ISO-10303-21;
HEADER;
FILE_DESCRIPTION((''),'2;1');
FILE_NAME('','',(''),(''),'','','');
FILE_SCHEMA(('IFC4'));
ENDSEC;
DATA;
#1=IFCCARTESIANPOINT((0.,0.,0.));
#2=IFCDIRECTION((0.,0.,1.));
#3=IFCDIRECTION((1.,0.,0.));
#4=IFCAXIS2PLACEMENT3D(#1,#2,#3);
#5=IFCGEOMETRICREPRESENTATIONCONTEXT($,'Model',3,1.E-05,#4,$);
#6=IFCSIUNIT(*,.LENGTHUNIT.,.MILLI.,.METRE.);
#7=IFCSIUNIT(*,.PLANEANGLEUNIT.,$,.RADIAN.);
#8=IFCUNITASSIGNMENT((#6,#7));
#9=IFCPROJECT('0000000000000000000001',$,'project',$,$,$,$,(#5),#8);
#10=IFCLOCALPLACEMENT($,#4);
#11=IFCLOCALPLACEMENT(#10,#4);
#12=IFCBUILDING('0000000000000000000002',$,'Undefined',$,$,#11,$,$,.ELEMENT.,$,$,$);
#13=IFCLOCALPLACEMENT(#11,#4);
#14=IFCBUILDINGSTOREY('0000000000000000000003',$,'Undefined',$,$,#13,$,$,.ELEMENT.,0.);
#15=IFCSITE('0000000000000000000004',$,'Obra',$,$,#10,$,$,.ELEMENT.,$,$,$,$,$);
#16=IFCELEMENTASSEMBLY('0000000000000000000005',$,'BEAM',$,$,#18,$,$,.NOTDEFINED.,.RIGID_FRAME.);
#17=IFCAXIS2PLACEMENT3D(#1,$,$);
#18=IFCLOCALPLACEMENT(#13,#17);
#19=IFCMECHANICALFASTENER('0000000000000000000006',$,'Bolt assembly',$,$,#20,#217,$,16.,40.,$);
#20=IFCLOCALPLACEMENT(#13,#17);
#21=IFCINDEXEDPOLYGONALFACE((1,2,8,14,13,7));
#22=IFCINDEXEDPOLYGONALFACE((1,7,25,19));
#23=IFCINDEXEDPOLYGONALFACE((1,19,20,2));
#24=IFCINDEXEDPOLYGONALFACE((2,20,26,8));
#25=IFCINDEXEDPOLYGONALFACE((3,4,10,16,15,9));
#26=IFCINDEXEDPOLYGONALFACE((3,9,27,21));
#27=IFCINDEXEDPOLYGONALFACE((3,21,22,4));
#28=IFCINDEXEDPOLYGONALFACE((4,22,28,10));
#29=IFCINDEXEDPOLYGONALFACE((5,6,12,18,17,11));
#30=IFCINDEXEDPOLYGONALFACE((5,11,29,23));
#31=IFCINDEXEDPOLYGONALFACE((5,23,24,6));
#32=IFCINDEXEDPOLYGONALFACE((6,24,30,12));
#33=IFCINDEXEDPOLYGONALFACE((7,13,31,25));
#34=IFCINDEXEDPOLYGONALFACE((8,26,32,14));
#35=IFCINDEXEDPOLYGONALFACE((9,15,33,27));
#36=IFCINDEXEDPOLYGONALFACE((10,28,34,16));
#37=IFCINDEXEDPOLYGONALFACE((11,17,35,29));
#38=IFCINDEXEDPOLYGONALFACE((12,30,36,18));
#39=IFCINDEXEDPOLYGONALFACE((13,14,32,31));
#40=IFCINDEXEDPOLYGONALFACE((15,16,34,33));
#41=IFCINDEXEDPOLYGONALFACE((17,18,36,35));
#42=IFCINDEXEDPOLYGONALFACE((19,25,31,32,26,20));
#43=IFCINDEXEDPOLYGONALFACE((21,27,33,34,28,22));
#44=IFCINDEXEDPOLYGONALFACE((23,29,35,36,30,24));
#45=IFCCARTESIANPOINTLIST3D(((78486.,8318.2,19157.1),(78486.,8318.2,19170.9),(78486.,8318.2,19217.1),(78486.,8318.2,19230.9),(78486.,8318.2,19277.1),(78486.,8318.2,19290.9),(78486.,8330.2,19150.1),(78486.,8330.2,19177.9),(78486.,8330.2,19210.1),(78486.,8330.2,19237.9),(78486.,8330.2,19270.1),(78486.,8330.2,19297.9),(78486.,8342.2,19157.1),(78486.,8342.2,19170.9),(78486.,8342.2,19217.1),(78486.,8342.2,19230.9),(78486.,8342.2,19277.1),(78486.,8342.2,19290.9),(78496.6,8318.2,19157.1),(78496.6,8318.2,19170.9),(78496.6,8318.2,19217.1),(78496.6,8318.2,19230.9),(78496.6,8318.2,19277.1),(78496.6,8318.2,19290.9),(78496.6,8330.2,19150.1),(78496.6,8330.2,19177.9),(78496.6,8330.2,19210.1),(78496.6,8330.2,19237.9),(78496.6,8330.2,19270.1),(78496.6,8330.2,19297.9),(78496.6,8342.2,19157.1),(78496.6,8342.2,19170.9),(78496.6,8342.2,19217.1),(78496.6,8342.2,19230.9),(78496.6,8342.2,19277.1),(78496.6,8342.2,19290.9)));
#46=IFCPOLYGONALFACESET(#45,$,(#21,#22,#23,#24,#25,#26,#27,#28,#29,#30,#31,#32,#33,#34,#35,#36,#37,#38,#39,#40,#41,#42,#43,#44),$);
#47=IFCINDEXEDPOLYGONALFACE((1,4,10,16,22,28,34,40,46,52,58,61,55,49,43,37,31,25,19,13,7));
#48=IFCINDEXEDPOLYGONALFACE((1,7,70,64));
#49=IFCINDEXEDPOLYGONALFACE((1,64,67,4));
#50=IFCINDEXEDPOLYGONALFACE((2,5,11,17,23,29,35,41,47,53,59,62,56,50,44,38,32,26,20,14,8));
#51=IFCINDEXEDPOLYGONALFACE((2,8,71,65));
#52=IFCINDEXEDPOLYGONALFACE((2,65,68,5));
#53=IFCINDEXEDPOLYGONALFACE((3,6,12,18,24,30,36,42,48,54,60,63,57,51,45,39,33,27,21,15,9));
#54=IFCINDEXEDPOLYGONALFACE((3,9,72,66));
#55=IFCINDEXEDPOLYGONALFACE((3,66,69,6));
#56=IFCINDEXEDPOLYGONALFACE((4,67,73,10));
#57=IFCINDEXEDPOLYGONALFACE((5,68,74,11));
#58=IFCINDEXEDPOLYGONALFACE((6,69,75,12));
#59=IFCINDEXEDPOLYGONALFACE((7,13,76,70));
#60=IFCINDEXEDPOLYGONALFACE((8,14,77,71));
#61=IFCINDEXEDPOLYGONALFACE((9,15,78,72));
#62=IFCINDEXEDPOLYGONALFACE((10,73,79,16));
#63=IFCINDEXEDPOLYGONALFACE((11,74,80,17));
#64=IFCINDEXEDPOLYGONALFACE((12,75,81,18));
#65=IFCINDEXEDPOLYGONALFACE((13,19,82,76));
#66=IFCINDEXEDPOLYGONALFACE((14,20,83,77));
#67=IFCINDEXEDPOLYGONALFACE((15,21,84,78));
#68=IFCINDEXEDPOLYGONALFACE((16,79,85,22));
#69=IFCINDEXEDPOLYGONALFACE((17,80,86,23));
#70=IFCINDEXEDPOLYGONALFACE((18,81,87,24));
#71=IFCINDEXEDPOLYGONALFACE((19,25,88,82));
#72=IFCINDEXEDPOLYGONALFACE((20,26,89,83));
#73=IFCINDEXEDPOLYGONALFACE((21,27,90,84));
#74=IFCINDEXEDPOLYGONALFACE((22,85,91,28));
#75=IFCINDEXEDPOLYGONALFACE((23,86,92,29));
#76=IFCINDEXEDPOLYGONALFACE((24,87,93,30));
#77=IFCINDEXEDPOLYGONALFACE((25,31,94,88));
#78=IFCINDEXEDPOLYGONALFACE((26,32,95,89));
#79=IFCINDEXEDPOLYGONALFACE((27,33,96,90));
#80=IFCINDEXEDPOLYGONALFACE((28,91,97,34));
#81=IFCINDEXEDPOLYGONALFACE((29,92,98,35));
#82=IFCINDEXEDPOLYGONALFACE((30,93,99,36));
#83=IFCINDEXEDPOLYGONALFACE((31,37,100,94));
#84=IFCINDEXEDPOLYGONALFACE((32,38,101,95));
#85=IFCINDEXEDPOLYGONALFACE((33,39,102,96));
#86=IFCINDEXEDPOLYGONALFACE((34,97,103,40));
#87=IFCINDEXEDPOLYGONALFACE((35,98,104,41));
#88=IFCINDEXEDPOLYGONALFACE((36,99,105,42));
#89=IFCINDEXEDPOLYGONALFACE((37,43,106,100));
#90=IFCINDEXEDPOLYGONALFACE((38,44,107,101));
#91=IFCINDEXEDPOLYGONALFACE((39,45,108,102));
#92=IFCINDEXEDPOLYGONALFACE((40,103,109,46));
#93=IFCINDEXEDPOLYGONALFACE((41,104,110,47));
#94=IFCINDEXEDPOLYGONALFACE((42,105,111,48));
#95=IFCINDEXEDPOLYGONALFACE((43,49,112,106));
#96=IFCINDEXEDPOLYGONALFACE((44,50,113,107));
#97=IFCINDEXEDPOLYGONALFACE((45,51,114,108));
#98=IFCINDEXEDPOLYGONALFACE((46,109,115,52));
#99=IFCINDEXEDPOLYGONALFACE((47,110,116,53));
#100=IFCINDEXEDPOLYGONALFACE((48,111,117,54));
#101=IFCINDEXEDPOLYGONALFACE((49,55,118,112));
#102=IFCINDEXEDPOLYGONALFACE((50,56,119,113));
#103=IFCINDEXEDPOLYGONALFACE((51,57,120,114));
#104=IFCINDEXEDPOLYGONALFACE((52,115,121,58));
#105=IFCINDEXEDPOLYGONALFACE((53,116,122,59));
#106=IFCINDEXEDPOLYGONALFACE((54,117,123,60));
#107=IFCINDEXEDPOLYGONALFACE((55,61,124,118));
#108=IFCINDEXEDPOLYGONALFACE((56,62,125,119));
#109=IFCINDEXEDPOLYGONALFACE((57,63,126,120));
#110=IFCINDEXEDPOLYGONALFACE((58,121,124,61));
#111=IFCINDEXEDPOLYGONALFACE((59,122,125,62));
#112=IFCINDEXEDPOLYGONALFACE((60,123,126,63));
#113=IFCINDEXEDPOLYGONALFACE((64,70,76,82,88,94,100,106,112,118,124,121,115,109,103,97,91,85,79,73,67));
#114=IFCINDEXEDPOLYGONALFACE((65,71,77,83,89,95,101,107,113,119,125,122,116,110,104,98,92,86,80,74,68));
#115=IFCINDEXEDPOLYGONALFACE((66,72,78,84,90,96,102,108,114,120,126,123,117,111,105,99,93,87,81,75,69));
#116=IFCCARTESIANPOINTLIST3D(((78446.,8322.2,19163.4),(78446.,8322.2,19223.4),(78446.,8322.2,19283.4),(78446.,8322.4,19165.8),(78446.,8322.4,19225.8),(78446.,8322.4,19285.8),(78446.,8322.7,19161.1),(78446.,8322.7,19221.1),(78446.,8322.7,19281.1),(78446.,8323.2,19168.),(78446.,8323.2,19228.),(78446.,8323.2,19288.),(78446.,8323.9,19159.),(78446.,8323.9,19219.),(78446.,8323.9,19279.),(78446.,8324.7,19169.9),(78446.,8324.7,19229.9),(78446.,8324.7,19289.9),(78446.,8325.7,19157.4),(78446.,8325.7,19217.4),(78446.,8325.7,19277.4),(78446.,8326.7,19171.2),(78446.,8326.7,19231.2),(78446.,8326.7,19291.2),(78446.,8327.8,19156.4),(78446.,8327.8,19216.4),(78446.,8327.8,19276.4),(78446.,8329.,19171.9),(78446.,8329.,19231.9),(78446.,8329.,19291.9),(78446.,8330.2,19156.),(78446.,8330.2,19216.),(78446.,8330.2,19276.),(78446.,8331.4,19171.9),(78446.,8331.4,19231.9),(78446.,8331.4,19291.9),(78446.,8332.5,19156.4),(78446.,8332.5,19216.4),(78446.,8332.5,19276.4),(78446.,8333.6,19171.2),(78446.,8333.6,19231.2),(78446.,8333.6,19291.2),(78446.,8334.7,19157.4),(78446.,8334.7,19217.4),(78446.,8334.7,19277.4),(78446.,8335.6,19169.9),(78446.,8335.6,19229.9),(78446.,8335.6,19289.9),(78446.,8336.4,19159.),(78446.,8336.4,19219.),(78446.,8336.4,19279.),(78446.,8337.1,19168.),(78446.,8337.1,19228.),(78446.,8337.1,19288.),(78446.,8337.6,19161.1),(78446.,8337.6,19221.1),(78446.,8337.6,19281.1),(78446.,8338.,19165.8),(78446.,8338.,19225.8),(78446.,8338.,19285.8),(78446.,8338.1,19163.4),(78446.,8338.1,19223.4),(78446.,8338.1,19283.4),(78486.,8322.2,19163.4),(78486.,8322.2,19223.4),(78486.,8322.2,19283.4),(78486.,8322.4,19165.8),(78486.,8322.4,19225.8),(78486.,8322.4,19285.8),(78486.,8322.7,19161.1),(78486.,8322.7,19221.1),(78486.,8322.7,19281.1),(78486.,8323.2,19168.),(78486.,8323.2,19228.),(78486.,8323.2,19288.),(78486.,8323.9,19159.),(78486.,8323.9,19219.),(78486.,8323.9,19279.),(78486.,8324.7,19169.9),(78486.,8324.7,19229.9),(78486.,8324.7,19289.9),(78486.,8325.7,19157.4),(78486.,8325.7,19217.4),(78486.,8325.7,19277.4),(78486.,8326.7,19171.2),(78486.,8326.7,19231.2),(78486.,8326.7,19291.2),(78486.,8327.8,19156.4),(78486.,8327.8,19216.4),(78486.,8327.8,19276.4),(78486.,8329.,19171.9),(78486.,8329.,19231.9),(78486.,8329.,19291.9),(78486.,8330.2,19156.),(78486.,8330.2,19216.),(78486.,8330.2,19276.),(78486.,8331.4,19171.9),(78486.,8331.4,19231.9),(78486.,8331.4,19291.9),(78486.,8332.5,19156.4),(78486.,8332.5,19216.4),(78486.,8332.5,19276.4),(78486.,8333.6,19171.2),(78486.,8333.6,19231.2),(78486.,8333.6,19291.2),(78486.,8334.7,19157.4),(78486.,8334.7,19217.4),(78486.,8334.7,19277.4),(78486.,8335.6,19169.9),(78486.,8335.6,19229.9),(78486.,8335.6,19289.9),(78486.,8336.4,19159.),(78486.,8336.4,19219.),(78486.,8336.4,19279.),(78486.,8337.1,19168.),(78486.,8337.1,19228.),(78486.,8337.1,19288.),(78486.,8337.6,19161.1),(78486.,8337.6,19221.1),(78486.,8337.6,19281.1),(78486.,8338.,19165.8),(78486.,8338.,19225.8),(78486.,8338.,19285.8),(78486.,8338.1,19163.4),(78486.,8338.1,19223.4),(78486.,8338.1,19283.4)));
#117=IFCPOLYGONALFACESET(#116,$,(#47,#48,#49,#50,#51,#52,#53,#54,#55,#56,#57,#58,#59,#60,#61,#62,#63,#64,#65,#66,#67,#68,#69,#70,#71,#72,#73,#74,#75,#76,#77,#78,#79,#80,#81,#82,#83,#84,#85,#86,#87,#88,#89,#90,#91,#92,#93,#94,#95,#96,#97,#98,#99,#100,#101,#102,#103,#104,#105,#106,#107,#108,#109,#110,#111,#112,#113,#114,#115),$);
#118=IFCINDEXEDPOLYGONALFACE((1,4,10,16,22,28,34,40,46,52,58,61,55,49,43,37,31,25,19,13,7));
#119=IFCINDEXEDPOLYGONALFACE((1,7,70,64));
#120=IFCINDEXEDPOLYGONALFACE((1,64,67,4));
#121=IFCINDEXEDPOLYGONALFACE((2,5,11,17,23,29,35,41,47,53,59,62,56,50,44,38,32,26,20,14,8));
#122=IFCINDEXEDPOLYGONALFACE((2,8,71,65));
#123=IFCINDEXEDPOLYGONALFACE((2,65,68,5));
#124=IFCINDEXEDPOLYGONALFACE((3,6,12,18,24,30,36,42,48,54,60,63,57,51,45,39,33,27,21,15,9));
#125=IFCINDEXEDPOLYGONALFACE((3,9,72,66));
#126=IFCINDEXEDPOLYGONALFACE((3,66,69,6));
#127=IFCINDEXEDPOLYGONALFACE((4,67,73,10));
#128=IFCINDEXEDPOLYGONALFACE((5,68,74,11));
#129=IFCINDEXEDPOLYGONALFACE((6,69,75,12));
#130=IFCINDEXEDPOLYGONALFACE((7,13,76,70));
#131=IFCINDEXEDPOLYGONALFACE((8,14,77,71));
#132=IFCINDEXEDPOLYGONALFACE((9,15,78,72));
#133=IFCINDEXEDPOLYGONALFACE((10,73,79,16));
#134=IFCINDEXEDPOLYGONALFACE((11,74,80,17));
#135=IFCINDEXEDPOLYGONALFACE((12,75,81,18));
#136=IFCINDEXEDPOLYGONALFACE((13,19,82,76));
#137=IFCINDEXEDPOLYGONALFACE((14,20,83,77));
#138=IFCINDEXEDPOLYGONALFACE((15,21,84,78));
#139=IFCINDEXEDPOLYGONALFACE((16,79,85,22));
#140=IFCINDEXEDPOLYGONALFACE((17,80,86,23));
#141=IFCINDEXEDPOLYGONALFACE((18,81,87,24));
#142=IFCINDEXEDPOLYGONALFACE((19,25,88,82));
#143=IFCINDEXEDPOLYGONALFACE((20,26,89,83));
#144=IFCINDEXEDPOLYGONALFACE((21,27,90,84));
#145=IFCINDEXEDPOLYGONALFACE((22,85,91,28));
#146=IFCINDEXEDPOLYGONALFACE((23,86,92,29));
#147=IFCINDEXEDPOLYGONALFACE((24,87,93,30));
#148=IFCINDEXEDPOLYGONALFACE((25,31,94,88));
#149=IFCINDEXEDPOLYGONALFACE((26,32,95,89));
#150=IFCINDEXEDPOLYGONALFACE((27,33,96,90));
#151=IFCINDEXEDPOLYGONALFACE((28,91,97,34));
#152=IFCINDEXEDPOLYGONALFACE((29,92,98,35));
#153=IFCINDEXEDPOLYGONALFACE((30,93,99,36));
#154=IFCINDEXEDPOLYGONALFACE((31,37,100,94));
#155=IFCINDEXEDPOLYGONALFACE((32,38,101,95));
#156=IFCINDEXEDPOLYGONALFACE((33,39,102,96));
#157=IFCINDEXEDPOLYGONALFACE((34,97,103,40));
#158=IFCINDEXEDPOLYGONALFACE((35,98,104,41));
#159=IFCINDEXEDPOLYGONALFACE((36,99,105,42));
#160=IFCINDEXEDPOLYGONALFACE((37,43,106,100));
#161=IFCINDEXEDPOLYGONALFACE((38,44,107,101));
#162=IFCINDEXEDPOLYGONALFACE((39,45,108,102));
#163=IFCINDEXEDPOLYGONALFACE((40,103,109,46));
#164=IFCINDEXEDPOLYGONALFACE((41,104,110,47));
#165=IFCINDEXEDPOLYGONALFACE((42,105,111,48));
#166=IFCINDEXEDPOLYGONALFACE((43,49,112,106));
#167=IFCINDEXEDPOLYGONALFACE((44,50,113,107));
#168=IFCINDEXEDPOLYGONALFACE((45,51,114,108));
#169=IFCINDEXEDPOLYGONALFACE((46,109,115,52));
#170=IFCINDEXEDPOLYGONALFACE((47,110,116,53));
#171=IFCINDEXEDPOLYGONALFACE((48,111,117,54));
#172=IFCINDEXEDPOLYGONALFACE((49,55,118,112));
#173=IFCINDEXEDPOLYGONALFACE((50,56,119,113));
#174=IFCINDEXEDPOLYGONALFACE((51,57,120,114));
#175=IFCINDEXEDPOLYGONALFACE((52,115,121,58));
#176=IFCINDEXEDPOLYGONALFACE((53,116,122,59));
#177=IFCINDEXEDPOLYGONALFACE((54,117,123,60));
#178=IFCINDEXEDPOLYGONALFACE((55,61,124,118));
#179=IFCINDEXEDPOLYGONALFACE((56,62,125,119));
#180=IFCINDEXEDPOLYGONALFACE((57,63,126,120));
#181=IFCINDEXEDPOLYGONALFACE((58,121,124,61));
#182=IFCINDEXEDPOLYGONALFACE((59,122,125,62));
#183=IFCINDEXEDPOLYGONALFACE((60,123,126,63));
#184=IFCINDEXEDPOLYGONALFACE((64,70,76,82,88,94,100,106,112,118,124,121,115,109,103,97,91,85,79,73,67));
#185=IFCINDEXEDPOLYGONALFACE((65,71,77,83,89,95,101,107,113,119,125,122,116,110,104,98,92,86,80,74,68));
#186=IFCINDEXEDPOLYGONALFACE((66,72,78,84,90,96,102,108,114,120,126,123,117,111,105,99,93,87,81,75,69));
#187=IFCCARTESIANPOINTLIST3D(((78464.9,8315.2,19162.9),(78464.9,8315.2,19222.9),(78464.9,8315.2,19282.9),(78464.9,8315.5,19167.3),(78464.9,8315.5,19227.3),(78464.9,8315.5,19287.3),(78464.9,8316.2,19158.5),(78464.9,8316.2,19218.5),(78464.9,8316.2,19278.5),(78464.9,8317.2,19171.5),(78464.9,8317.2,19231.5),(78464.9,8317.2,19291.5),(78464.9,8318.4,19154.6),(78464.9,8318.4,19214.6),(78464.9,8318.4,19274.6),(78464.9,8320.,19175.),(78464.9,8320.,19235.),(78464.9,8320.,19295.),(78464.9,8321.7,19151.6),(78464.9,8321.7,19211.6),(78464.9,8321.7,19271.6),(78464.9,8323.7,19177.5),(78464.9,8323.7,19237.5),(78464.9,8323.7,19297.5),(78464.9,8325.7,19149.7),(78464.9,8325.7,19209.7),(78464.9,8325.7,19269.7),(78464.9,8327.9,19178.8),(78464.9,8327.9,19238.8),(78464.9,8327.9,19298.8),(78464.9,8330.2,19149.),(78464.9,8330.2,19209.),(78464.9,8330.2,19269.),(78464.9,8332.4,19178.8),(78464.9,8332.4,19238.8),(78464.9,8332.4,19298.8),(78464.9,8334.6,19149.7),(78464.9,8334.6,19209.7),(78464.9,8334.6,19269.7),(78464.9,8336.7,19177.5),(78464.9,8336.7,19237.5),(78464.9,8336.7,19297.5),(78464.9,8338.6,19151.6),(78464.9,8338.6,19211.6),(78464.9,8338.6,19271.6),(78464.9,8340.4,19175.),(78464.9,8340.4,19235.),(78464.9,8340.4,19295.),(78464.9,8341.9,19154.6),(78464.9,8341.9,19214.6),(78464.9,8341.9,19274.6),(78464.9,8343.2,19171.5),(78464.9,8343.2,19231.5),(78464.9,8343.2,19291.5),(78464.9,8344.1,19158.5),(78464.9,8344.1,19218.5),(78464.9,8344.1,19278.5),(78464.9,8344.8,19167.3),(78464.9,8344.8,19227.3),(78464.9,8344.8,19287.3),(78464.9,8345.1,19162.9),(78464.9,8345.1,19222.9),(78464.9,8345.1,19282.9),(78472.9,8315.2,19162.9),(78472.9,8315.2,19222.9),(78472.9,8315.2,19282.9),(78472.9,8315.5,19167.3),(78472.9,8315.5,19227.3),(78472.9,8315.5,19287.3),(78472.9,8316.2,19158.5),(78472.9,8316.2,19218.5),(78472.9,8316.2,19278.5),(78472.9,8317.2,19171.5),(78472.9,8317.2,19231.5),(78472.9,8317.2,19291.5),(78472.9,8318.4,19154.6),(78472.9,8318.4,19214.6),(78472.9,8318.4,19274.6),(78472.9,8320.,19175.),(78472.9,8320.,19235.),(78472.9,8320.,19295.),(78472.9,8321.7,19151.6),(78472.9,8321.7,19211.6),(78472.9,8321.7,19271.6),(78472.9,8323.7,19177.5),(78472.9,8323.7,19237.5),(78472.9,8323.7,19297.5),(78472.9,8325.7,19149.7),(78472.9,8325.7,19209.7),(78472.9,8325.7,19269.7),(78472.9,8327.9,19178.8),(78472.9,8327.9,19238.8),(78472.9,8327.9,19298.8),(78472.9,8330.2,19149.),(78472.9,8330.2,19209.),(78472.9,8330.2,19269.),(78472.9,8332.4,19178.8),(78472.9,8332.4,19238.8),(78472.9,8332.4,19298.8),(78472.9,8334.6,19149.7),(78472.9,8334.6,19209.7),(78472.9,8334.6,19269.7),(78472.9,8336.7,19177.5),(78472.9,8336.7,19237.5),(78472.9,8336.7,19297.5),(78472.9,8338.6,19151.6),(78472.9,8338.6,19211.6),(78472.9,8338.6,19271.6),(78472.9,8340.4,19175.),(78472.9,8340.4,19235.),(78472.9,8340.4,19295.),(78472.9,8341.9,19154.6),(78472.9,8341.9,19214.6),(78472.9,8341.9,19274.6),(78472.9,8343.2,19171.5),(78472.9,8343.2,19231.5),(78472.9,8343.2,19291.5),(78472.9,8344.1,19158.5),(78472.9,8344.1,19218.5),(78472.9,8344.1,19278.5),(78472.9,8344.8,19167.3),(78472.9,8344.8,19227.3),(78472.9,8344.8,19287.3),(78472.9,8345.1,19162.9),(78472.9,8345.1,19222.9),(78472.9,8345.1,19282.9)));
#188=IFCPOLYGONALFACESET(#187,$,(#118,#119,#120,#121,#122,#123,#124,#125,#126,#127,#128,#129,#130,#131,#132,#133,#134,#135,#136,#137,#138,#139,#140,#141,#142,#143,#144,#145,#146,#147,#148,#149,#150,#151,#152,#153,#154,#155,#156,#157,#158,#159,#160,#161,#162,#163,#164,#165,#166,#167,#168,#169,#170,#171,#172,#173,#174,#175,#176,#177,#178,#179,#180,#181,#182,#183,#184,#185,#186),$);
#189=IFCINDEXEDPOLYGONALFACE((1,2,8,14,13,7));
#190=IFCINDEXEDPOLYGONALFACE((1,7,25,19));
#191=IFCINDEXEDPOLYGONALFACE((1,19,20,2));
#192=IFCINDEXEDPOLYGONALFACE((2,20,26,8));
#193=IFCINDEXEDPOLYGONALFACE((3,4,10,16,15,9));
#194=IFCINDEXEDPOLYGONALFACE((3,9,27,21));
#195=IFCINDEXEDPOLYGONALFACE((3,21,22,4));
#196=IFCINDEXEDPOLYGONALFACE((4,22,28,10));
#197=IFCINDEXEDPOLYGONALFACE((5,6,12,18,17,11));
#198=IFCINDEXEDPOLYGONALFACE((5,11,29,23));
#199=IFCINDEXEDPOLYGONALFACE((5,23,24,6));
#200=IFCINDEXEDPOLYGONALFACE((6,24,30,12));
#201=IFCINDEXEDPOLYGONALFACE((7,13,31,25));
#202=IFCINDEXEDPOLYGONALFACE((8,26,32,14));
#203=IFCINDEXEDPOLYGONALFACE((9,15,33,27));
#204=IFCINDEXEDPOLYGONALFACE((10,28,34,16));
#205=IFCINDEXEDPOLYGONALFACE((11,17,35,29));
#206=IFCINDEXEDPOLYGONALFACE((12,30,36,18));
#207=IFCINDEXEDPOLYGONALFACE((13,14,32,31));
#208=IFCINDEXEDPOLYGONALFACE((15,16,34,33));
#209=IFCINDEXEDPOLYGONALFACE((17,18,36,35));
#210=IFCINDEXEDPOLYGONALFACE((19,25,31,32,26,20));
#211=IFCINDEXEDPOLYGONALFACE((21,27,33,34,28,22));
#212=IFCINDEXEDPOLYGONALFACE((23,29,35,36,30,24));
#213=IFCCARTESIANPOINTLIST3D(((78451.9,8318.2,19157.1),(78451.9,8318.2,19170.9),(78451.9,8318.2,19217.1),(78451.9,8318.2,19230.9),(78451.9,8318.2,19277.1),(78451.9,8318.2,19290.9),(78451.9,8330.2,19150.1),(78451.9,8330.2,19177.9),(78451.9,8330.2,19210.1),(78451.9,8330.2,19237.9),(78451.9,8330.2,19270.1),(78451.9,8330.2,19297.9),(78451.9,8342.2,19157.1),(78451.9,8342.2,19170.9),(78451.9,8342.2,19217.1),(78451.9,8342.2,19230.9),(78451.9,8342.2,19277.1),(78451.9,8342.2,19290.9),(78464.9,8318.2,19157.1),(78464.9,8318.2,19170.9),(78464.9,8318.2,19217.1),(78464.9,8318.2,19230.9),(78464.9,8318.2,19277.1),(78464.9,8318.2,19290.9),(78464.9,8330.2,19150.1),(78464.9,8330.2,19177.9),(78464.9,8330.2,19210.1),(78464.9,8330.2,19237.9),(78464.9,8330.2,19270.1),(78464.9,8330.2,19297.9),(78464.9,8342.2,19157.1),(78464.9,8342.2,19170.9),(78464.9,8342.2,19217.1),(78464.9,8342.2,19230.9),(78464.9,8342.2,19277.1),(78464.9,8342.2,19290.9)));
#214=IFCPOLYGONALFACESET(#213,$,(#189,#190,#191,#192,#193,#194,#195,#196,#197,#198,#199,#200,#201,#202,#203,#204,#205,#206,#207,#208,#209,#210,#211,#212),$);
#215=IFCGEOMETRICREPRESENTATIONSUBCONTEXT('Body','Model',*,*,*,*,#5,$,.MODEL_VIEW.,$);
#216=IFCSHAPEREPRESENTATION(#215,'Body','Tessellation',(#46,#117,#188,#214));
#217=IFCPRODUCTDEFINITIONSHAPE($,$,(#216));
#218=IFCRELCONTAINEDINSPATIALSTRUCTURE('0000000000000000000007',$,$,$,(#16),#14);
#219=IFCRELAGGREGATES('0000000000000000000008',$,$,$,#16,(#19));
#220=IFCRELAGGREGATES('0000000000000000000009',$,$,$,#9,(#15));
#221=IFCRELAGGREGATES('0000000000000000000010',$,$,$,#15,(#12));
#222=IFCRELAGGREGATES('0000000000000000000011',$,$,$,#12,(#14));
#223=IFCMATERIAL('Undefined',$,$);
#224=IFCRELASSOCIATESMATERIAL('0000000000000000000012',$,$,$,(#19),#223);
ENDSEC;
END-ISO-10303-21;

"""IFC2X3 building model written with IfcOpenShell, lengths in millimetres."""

from ifc_helpers import new_model, si_unit, frame, origin_with_axes, origin_2d_with_axis, place, context, subcontext, project, spatial, polyline, circle, outline, extrude, source, transform, mapped, material, element, aggregate, save


model = new_model("IFC2X3")

# Units and contexts
model_context = context("Model", 3, precision=1e-05, world=origin_with_axes())
body_context = subcontext(model_context, "Body", "Model", "MODEL_VIEW")
ifc_project = project(units=[si_unit("LENGTHUNIT", "METRE", prefix="MILLI"), si_unit("PLANEANGLEUNIT", "RADIAN")], contexts=[model_context])

# Site, building, storey
site_placement = place(None, origin_with_axes())
site = spatial("IfcSite", under=ifc_project, at=site_placement, Name="Obra", CompositionType="ELEMENT")
building_placement = place(site_placement, origin_with_axes())
building = spatial("IfcBuilding", under=site, at=building_placement, Name="Undefined", CompositionType="ELEMENT")
storey_placement = place(building_placement, origin_with_axes())
storey = spatial("IfcBuildingStorey", under=building, at=storey_placement, Name="Undefined", CompositionType="ELEMENT", Elevation=0.0)

# Element assembly
assembly_1_placement = place(storey_placement, origin_with_axes())
assembly_1 = element("IfcElementAssembly", 1, at=assembly_1_placement, inside=storey, Name="BEAM", AssemblyPlace="NOTDEFINED", PredefinedType="RIGID_FRAME")

# Shared definitions
ifc_material_1 = material(Name="Undefined")

# Shared definitions
shared_shape_1 = source(origin_with_axes(), body_context, "Body", "SweptSolid", [
    extrude(outline(polyline([(13.9, 0.0), (6.9, 12.0), (-6.9, 12.0), (-13.9, 0.0), (-6.9, -12.0), (6.9, -12.0), (13.9, 0.0)])), frame((0.0, -14.1, 0.0), z_axis=(0.0, 1.0, 0.0), x_axis=(1.0, 0.0, 0.0)), (0.0, 0.0, 1.0), 10.6),
    extrude(circle(Radius=8.0, at=origin_2d_with_axis()), frame((0.0, -3.6, 0.0), z_axis=(0.0, 1.0, 0.0), x_axis=(1.0, 0.0, 0.0)), (0.0, 0.0, 1.0), 40.0),
    extrude(circle(Radius=15.0, at=origin_2d_with_axis()), frame((0.0, 9.5, 0.0), z_axis=(0.0, 1.0, 0.0), x_axis=(1.0, 0.0, 0.0)), (0.0, 0.0, 1.0), 8.0),
    extrude(outline(polyline([(13.9, 0.0), (6.9, 12.0), (-6.9, 12.0), (-13.9, 0.0), (-6.9, -12.0), (6.9, -12.0), (13.9, 0.0)])), frame((0.0, 17.5, 0.0), z_axis=(0.0, 1.0, 0.0), x_axis=(1.0, 0.0, 0.0)), (0.0, 0.0, 1.0), 13.0),
])

# Mechanical fastener
mechanical_fastener_1_placement = place(assembly_1_placement, frame((78482.5, 8280.2, 19319.0), z_axis=(-0.000014, 1.0, 0.0), x_axis=(0.0, 0.0, -1.0)))
mechanical_fastener_1 = element("IfcMechanicalFastener", 2, at=mechanical_fastener_1_placement, material=ifc_material_1, Name="Bolt assembly", NominalDiameter=16.0, NominalLength=40.0, context=body_context, shape_type="MappedRepresentation", body=[
    mapped(shared_shape_1, transform((35.0, 0.0, 50.0))),
    mapped(shared_shape_1, transform((95.0, 0.0, 50.0))),
    mapped(shared_shape_1, transform((155.0, 0.0, 50.0))),
])
aggregate(assembly_1, [mechanical_fastener_1])

save(model, "model.ifc")
